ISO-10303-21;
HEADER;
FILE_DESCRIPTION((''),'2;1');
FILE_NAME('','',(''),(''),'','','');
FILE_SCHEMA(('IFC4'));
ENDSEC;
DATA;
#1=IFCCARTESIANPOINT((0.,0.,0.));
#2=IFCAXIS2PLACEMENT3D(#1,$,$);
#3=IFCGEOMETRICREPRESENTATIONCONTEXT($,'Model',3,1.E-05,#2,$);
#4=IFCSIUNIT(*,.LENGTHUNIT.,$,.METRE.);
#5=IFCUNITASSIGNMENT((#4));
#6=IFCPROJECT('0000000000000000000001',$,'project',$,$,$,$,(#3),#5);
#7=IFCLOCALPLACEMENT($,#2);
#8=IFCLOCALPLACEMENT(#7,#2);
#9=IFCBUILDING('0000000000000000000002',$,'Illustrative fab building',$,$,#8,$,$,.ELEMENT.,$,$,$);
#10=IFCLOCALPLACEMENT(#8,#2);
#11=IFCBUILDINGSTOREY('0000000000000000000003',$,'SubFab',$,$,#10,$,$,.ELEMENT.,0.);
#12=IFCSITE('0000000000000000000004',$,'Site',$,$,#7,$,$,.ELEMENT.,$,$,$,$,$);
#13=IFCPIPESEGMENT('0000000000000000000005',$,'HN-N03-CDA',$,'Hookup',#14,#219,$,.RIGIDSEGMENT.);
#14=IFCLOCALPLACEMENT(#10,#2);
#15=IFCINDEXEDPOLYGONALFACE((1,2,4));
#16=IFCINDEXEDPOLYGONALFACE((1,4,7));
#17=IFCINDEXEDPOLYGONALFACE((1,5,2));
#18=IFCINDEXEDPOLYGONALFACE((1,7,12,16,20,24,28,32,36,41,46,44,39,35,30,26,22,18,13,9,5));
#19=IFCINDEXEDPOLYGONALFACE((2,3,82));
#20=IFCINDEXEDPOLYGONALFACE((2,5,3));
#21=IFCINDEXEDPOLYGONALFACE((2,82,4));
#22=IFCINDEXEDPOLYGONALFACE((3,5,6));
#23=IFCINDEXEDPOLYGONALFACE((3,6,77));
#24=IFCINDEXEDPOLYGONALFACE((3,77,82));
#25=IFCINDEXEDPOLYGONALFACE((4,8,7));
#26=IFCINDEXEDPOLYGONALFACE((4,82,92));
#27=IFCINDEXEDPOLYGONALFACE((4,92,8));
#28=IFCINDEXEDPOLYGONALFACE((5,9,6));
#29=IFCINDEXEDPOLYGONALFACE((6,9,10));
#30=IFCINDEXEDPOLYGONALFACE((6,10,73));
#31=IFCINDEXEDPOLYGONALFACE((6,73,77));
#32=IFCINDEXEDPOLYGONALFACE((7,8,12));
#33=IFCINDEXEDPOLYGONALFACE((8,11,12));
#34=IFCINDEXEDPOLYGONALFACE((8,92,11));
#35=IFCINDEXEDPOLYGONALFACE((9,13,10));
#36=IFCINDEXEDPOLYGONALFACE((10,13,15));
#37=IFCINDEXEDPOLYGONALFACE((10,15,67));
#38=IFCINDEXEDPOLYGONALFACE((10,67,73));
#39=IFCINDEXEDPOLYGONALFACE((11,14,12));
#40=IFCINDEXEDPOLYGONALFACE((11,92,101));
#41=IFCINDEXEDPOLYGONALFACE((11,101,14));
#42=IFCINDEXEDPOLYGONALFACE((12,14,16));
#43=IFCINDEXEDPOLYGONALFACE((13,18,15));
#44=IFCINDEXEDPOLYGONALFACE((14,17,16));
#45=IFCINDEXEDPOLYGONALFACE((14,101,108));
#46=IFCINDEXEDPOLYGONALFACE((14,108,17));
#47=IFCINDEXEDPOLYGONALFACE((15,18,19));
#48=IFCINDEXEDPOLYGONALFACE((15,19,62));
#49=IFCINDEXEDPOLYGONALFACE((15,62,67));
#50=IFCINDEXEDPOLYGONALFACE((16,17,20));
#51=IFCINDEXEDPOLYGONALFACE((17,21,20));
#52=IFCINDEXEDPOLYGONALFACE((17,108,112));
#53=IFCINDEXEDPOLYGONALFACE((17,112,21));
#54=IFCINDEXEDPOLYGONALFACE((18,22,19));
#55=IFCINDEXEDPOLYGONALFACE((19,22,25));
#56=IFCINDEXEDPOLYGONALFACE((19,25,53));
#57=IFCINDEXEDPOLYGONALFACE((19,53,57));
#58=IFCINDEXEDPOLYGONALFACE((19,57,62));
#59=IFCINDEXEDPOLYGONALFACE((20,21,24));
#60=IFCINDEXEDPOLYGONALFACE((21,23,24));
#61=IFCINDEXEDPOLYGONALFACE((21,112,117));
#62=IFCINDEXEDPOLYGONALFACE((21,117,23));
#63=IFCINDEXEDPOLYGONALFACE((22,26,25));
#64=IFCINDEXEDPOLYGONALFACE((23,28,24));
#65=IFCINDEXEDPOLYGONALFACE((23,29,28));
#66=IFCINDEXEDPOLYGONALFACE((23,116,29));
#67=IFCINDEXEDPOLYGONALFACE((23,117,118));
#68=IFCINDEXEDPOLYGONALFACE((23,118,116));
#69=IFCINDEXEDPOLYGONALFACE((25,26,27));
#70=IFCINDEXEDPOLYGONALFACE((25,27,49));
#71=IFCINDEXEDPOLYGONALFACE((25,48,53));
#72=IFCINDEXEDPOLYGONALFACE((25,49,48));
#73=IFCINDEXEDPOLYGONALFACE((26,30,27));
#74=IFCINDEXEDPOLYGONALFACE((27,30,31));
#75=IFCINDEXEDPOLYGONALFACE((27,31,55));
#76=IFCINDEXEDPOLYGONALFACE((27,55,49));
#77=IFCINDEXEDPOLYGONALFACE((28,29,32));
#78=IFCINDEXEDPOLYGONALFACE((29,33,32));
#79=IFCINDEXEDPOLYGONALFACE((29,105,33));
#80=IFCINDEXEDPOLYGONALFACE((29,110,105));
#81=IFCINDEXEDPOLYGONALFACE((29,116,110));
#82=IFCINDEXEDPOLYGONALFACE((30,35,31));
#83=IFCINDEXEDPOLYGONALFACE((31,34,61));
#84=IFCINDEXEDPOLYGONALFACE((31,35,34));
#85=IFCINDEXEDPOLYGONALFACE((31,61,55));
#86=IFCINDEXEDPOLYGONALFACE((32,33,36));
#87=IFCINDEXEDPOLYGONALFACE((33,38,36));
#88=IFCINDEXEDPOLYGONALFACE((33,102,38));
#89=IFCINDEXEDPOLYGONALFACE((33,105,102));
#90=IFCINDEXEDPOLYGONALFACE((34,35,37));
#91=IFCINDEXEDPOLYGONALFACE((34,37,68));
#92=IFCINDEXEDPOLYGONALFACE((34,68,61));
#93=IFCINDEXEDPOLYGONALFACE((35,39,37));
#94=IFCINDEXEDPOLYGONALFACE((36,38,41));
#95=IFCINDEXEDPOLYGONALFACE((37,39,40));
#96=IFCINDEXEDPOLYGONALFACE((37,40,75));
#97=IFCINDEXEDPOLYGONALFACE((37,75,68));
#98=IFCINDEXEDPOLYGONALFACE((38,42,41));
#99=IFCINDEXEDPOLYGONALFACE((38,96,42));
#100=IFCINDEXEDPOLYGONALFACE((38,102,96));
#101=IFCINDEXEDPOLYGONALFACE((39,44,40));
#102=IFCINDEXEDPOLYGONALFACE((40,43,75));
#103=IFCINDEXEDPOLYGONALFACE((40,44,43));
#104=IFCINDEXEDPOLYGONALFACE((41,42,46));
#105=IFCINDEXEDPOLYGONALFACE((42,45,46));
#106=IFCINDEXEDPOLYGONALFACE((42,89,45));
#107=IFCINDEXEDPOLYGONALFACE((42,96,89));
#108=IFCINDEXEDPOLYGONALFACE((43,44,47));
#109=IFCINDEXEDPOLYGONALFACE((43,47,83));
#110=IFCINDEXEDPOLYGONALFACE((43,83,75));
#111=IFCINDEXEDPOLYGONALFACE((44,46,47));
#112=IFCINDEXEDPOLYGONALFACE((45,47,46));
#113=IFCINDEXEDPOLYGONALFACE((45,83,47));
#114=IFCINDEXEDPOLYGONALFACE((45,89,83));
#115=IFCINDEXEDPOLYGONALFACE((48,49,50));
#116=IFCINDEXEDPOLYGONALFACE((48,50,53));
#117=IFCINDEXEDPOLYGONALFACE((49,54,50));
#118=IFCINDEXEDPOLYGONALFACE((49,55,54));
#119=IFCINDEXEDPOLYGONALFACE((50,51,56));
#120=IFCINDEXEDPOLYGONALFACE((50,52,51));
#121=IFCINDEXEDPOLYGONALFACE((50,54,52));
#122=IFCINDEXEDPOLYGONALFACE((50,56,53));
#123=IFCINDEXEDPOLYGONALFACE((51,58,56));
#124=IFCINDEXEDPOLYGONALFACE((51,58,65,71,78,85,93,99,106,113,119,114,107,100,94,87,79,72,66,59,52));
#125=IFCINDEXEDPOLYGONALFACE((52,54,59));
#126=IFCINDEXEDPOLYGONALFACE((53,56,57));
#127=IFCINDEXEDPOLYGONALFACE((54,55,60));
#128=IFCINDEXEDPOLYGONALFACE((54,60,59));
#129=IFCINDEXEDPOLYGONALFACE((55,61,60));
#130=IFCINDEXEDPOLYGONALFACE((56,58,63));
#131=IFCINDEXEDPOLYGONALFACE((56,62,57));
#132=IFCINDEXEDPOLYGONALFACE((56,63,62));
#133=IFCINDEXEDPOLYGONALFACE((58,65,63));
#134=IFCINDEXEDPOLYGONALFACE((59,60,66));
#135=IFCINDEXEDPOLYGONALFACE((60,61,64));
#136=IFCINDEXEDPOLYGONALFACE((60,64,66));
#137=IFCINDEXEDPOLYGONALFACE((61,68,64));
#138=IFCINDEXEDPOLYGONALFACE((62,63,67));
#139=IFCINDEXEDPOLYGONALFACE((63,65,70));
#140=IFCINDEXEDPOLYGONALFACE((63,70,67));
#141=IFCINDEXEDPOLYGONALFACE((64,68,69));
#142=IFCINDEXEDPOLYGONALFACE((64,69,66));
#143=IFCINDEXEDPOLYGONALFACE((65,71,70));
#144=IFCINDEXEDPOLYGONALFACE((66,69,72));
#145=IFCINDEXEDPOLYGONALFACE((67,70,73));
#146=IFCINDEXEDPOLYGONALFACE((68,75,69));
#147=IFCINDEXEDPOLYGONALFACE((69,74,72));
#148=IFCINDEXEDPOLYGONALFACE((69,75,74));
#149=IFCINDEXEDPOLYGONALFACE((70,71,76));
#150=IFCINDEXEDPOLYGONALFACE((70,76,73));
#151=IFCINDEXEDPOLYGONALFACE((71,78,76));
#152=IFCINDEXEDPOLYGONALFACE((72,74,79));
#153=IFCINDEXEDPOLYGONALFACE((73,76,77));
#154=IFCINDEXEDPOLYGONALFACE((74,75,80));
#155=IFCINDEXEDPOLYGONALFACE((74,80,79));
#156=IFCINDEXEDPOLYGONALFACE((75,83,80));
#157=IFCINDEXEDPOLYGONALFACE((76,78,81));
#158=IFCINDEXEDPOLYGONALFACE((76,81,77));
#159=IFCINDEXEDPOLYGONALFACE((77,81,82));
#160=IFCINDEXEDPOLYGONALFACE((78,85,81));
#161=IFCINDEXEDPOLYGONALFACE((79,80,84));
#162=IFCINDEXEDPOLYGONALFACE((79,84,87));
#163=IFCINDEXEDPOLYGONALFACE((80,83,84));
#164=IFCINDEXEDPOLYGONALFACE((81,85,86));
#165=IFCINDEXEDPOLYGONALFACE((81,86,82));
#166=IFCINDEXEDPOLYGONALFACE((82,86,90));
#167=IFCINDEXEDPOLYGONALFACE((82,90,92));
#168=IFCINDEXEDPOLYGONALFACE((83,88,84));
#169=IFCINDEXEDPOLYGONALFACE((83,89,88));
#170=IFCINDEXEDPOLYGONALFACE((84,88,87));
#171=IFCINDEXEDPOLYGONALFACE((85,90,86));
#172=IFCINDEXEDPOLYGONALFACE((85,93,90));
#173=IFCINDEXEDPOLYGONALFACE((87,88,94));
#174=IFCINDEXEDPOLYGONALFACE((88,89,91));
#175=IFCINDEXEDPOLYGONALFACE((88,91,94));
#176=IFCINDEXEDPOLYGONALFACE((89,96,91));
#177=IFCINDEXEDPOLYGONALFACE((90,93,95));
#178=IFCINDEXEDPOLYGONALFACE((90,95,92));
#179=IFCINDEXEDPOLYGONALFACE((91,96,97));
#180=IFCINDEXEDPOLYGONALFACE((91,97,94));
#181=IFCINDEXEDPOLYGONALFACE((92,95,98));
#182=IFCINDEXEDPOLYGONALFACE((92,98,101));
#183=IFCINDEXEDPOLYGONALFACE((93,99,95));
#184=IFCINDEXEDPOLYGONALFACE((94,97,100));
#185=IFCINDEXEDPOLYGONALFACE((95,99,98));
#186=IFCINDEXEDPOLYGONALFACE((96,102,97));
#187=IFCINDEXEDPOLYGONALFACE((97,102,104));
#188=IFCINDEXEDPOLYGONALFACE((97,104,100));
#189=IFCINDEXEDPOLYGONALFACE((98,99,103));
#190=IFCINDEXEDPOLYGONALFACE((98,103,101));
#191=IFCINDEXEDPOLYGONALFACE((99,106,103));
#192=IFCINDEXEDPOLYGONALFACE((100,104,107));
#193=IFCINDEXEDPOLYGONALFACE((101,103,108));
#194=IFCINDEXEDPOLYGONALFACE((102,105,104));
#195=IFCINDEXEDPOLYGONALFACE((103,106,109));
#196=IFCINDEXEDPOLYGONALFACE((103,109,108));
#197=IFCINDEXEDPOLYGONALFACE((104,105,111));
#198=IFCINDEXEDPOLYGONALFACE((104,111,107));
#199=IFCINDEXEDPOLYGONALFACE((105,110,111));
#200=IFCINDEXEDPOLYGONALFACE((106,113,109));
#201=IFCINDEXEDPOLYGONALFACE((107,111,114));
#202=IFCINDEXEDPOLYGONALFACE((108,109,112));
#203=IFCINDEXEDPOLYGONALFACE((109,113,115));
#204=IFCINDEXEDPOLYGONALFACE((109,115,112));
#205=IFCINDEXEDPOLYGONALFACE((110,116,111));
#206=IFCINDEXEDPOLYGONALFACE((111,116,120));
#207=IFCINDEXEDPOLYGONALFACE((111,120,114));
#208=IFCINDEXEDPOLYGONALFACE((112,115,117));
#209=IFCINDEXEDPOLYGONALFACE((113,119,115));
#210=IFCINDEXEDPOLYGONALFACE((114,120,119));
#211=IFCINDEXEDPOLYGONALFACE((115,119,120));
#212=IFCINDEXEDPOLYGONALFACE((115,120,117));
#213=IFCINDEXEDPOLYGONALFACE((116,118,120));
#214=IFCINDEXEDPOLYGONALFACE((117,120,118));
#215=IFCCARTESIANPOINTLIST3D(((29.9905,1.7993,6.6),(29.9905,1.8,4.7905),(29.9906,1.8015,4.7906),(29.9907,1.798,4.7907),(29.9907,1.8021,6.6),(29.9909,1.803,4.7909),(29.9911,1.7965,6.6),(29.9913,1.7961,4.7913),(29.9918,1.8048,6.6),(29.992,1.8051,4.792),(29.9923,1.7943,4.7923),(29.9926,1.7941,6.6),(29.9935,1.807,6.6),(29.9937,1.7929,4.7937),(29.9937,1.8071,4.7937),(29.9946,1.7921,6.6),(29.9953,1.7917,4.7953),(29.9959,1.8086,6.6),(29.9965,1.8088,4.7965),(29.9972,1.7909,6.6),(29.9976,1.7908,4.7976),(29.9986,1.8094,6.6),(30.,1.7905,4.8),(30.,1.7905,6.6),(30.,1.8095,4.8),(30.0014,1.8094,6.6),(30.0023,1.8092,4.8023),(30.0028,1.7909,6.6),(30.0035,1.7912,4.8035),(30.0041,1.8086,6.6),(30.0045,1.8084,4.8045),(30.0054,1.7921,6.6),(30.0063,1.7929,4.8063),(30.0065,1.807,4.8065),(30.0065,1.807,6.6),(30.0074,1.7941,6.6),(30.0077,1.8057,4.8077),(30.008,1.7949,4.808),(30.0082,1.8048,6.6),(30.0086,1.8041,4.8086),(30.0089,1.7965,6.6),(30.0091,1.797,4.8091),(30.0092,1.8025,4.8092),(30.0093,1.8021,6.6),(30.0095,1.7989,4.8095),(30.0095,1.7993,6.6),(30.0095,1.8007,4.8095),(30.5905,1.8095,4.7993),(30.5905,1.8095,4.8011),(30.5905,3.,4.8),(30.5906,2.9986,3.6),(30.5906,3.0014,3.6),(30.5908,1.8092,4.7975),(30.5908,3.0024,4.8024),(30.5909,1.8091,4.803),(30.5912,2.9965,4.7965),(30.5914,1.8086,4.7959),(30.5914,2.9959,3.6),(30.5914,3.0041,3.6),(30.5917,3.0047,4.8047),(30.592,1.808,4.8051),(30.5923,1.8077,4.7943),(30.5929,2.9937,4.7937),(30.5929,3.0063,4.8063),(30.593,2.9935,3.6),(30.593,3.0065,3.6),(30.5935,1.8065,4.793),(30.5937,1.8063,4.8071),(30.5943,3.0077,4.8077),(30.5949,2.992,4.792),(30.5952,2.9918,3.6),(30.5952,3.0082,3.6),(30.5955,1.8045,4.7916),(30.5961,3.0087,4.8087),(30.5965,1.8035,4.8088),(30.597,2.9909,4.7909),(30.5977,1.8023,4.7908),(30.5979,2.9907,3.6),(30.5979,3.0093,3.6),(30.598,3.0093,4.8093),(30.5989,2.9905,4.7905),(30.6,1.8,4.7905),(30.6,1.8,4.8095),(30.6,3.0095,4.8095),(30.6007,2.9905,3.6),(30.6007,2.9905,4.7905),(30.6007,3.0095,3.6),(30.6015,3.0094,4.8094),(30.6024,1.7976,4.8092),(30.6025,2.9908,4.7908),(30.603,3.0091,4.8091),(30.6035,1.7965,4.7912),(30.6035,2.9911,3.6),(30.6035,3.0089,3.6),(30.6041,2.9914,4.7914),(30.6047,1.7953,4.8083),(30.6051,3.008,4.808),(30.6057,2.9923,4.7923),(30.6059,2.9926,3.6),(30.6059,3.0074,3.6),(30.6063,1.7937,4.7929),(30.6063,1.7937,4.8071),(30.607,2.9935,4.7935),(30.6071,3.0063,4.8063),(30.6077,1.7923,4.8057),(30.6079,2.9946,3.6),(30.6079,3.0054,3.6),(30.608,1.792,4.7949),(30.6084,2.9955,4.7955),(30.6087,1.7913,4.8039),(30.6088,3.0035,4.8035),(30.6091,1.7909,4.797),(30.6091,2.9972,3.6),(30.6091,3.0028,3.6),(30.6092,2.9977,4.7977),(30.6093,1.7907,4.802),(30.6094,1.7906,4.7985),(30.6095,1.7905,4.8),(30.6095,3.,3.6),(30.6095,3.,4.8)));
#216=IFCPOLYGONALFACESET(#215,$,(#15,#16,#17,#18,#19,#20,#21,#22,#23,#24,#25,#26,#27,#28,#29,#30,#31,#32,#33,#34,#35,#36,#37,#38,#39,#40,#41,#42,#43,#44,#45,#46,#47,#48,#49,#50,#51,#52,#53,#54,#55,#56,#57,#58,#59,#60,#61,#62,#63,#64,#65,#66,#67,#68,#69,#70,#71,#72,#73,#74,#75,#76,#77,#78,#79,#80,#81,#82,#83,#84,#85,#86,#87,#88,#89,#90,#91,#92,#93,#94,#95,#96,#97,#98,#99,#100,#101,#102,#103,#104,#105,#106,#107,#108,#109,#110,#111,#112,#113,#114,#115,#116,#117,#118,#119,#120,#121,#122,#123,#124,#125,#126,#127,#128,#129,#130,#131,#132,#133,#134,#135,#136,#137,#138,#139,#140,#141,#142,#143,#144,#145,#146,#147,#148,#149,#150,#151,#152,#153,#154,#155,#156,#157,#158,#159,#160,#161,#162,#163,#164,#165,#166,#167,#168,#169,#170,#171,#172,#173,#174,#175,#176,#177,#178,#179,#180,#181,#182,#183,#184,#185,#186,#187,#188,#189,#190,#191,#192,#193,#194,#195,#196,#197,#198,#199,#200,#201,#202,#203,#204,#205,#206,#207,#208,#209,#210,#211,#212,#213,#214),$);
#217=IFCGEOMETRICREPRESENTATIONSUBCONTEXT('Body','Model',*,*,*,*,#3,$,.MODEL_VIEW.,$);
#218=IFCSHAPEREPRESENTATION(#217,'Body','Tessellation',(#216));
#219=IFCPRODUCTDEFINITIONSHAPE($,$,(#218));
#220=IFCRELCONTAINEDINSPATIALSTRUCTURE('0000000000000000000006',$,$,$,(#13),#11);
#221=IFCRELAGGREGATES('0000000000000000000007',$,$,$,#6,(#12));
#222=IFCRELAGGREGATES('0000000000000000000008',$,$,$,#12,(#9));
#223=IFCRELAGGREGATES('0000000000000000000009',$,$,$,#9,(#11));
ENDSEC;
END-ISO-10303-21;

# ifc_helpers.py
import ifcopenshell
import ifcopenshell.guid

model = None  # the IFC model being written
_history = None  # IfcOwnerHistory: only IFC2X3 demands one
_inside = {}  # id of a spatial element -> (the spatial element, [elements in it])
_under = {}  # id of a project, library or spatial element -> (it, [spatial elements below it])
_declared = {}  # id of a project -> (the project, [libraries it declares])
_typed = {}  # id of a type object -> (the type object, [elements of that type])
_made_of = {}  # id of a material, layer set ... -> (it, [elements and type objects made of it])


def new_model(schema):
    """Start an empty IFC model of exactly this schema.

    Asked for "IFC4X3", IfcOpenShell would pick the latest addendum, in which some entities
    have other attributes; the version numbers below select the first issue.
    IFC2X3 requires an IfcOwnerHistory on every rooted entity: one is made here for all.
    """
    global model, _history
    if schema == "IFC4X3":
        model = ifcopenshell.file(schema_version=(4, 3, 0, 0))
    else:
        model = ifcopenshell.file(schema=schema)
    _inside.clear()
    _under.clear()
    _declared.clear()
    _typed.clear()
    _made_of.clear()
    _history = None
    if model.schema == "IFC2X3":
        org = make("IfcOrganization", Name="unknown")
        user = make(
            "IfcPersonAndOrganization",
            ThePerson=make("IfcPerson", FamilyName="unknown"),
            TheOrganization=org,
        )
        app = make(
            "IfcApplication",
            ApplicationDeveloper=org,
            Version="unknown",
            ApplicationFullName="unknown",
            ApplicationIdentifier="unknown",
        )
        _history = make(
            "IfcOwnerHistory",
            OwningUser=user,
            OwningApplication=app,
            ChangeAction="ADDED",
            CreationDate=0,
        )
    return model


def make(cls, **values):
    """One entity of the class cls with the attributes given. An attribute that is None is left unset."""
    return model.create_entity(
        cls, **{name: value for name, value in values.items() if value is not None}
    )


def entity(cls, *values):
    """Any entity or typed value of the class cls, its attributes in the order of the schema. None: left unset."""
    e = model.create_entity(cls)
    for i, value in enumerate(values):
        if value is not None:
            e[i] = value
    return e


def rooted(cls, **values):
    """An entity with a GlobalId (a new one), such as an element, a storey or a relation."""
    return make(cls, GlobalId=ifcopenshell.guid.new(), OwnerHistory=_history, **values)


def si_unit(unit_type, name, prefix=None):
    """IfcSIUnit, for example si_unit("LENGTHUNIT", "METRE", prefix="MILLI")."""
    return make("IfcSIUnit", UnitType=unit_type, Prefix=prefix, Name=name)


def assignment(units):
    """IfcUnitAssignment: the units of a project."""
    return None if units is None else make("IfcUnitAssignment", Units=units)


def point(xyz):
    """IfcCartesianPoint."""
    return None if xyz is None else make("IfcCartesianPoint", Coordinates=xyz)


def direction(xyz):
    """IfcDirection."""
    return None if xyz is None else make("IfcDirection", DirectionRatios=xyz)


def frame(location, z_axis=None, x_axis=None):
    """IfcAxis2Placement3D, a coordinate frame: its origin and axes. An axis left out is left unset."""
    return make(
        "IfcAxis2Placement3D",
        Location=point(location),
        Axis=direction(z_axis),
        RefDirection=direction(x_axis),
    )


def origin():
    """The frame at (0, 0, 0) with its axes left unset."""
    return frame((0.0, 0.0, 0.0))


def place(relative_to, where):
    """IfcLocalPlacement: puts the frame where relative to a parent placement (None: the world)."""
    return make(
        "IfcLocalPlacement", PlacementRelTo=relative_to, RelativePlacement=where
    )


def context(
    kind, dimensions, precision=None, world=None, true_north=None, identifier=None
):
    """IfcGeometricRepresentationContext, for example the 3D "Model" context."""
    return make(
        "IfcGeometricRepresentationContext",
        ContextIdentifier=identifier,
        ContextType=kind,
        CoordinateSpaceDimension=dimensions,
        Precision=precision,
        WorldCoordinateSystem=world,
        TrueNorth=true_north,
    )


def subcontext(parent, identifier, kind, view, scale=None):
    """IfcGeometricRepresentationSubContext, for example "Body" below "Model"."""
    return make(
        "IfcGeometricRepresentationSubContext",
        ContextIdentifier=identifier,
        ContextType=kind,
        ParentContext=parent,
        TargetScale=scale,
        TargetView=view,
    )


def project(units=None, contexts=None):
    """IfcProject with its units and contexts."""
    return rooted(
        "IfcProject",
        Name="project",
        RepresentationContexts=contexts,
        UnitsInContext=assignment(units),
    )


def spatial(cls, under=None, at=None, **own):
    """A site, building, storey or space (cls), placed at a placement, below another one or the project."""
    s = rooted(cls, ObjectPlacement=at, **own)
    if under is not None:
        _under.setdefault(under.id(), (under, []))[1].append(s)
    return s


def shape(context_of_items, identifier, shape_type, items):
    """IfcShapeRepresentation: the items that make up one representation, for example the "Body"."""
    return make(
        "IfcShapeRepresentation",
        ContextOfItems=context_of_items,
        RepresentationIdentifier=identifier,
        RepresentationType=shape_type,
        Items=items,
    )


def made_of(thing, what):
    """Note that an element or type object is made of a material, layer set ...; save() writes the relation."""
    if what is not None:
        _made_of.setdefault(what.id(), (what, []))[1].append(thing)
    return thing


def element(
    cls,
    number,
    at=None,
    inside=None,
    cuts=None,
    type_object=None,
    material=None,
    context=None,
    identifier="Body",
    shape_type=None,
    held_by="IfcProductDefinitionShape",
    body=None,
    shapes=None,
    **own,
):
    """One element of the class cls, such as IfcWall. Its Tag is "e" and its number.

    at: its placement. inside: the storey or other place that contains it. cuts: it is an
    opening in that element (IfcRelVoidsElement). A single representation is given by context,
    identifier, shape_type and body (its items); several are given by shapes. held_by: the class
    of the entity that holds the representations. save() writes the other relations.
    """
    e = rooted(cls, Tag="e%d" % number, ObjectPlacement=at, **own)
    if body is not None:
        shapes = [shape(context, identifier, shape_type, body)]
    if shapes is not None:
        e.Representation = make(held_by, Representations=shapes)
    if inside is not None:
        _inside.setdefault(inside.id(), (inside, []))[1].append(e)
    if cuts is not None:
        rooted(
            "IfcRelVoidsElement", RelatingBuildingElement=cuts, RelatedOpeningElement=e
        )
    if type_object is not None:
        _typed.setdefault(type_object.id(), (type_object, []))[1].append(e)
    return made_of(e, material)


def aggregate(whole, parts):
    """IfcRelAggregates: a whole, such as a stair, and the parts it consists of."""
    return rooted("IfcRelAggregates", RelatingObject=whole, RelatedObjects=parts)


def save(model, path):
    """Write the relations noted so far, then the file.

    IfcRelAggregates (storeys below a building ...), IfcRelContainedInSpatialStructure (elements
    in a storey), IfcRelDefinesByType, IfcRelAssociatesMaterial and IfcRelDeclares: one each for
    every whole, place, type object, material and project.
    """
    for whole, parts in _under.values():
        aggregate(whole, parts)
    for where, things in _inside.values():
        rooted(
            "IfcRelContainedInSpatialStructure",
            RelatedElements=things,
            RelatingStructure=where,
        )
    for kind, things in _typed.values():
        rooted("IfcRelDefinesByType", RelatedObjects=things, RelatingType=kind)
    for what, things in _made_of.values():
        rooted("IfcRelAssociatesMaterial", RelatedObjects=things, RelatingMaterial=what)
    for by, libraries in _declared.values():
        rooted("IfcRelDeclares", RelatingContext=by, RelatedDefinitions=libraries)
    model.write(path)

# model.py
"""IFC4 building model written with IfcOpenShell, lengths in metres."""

from ifc_helpers import new_model, entity, si_unit, origin, place, context, subcontext, project, spatial, element, save


model = new_model("IFC4")

# Units and contexts
model_context = context("Model", 3, precision=1e-05, world=origin())
body_context = subcontext(model_context, "Body", "Model", "MODEL_VIEW")
ifc_project = project(units=[si_unit("LENGTHUNIT", "METRE")], contexts=[model_context])

# Site, building, storey
site_placement = place(None, origin())
site = spatial("IfcSite", under=ifc_project, at=site_placement, Name="Site", CompositionType="ELEMENT")
building_placement = place(site_placement, origin())
building = spatial("IfcBuilding", under=site, at=building_placement, Name="Illustrative fab building", CompositionType="ELEMENT")
storey_placement = place(building_placement, origin())
storey = spatial("IfcBuildingStorey", under=building, at=storey_placement, Name="SubFab", CompositionType="ELEMENT", Elevation=0.0)

# Pipe segment
pipe_segment_1_placement = place(storey_placement, origin())
element("IfcPipeSegment", 1, at=pipe_segment_1_placement, inside=storey, Name="HN-N03-CDA", ObjectType="Hookup", PredefinedType="RIGIDSEGMENT", context=body_context, shape_type="AdvancedSweptSolid", body=[
    entity("IfcSweptDiskSolid", entity("IfcPolyline", [entity("IfcCartesianPoint", [30.6, 3.0, 3.6]), entity("IfcCartesianPoint", [30.6, 3.0, 4.8]), entity("IfcCartesianPoint", [30.6, 1.8, 4.8]), entity("IfcCartesianPoint", [30.0, 1.8, 4.8]), entity("IfcCartesianPoint", [30.0, 1.8, 6.6])]), 0.0095),
])

save(model, "model.ifc")
